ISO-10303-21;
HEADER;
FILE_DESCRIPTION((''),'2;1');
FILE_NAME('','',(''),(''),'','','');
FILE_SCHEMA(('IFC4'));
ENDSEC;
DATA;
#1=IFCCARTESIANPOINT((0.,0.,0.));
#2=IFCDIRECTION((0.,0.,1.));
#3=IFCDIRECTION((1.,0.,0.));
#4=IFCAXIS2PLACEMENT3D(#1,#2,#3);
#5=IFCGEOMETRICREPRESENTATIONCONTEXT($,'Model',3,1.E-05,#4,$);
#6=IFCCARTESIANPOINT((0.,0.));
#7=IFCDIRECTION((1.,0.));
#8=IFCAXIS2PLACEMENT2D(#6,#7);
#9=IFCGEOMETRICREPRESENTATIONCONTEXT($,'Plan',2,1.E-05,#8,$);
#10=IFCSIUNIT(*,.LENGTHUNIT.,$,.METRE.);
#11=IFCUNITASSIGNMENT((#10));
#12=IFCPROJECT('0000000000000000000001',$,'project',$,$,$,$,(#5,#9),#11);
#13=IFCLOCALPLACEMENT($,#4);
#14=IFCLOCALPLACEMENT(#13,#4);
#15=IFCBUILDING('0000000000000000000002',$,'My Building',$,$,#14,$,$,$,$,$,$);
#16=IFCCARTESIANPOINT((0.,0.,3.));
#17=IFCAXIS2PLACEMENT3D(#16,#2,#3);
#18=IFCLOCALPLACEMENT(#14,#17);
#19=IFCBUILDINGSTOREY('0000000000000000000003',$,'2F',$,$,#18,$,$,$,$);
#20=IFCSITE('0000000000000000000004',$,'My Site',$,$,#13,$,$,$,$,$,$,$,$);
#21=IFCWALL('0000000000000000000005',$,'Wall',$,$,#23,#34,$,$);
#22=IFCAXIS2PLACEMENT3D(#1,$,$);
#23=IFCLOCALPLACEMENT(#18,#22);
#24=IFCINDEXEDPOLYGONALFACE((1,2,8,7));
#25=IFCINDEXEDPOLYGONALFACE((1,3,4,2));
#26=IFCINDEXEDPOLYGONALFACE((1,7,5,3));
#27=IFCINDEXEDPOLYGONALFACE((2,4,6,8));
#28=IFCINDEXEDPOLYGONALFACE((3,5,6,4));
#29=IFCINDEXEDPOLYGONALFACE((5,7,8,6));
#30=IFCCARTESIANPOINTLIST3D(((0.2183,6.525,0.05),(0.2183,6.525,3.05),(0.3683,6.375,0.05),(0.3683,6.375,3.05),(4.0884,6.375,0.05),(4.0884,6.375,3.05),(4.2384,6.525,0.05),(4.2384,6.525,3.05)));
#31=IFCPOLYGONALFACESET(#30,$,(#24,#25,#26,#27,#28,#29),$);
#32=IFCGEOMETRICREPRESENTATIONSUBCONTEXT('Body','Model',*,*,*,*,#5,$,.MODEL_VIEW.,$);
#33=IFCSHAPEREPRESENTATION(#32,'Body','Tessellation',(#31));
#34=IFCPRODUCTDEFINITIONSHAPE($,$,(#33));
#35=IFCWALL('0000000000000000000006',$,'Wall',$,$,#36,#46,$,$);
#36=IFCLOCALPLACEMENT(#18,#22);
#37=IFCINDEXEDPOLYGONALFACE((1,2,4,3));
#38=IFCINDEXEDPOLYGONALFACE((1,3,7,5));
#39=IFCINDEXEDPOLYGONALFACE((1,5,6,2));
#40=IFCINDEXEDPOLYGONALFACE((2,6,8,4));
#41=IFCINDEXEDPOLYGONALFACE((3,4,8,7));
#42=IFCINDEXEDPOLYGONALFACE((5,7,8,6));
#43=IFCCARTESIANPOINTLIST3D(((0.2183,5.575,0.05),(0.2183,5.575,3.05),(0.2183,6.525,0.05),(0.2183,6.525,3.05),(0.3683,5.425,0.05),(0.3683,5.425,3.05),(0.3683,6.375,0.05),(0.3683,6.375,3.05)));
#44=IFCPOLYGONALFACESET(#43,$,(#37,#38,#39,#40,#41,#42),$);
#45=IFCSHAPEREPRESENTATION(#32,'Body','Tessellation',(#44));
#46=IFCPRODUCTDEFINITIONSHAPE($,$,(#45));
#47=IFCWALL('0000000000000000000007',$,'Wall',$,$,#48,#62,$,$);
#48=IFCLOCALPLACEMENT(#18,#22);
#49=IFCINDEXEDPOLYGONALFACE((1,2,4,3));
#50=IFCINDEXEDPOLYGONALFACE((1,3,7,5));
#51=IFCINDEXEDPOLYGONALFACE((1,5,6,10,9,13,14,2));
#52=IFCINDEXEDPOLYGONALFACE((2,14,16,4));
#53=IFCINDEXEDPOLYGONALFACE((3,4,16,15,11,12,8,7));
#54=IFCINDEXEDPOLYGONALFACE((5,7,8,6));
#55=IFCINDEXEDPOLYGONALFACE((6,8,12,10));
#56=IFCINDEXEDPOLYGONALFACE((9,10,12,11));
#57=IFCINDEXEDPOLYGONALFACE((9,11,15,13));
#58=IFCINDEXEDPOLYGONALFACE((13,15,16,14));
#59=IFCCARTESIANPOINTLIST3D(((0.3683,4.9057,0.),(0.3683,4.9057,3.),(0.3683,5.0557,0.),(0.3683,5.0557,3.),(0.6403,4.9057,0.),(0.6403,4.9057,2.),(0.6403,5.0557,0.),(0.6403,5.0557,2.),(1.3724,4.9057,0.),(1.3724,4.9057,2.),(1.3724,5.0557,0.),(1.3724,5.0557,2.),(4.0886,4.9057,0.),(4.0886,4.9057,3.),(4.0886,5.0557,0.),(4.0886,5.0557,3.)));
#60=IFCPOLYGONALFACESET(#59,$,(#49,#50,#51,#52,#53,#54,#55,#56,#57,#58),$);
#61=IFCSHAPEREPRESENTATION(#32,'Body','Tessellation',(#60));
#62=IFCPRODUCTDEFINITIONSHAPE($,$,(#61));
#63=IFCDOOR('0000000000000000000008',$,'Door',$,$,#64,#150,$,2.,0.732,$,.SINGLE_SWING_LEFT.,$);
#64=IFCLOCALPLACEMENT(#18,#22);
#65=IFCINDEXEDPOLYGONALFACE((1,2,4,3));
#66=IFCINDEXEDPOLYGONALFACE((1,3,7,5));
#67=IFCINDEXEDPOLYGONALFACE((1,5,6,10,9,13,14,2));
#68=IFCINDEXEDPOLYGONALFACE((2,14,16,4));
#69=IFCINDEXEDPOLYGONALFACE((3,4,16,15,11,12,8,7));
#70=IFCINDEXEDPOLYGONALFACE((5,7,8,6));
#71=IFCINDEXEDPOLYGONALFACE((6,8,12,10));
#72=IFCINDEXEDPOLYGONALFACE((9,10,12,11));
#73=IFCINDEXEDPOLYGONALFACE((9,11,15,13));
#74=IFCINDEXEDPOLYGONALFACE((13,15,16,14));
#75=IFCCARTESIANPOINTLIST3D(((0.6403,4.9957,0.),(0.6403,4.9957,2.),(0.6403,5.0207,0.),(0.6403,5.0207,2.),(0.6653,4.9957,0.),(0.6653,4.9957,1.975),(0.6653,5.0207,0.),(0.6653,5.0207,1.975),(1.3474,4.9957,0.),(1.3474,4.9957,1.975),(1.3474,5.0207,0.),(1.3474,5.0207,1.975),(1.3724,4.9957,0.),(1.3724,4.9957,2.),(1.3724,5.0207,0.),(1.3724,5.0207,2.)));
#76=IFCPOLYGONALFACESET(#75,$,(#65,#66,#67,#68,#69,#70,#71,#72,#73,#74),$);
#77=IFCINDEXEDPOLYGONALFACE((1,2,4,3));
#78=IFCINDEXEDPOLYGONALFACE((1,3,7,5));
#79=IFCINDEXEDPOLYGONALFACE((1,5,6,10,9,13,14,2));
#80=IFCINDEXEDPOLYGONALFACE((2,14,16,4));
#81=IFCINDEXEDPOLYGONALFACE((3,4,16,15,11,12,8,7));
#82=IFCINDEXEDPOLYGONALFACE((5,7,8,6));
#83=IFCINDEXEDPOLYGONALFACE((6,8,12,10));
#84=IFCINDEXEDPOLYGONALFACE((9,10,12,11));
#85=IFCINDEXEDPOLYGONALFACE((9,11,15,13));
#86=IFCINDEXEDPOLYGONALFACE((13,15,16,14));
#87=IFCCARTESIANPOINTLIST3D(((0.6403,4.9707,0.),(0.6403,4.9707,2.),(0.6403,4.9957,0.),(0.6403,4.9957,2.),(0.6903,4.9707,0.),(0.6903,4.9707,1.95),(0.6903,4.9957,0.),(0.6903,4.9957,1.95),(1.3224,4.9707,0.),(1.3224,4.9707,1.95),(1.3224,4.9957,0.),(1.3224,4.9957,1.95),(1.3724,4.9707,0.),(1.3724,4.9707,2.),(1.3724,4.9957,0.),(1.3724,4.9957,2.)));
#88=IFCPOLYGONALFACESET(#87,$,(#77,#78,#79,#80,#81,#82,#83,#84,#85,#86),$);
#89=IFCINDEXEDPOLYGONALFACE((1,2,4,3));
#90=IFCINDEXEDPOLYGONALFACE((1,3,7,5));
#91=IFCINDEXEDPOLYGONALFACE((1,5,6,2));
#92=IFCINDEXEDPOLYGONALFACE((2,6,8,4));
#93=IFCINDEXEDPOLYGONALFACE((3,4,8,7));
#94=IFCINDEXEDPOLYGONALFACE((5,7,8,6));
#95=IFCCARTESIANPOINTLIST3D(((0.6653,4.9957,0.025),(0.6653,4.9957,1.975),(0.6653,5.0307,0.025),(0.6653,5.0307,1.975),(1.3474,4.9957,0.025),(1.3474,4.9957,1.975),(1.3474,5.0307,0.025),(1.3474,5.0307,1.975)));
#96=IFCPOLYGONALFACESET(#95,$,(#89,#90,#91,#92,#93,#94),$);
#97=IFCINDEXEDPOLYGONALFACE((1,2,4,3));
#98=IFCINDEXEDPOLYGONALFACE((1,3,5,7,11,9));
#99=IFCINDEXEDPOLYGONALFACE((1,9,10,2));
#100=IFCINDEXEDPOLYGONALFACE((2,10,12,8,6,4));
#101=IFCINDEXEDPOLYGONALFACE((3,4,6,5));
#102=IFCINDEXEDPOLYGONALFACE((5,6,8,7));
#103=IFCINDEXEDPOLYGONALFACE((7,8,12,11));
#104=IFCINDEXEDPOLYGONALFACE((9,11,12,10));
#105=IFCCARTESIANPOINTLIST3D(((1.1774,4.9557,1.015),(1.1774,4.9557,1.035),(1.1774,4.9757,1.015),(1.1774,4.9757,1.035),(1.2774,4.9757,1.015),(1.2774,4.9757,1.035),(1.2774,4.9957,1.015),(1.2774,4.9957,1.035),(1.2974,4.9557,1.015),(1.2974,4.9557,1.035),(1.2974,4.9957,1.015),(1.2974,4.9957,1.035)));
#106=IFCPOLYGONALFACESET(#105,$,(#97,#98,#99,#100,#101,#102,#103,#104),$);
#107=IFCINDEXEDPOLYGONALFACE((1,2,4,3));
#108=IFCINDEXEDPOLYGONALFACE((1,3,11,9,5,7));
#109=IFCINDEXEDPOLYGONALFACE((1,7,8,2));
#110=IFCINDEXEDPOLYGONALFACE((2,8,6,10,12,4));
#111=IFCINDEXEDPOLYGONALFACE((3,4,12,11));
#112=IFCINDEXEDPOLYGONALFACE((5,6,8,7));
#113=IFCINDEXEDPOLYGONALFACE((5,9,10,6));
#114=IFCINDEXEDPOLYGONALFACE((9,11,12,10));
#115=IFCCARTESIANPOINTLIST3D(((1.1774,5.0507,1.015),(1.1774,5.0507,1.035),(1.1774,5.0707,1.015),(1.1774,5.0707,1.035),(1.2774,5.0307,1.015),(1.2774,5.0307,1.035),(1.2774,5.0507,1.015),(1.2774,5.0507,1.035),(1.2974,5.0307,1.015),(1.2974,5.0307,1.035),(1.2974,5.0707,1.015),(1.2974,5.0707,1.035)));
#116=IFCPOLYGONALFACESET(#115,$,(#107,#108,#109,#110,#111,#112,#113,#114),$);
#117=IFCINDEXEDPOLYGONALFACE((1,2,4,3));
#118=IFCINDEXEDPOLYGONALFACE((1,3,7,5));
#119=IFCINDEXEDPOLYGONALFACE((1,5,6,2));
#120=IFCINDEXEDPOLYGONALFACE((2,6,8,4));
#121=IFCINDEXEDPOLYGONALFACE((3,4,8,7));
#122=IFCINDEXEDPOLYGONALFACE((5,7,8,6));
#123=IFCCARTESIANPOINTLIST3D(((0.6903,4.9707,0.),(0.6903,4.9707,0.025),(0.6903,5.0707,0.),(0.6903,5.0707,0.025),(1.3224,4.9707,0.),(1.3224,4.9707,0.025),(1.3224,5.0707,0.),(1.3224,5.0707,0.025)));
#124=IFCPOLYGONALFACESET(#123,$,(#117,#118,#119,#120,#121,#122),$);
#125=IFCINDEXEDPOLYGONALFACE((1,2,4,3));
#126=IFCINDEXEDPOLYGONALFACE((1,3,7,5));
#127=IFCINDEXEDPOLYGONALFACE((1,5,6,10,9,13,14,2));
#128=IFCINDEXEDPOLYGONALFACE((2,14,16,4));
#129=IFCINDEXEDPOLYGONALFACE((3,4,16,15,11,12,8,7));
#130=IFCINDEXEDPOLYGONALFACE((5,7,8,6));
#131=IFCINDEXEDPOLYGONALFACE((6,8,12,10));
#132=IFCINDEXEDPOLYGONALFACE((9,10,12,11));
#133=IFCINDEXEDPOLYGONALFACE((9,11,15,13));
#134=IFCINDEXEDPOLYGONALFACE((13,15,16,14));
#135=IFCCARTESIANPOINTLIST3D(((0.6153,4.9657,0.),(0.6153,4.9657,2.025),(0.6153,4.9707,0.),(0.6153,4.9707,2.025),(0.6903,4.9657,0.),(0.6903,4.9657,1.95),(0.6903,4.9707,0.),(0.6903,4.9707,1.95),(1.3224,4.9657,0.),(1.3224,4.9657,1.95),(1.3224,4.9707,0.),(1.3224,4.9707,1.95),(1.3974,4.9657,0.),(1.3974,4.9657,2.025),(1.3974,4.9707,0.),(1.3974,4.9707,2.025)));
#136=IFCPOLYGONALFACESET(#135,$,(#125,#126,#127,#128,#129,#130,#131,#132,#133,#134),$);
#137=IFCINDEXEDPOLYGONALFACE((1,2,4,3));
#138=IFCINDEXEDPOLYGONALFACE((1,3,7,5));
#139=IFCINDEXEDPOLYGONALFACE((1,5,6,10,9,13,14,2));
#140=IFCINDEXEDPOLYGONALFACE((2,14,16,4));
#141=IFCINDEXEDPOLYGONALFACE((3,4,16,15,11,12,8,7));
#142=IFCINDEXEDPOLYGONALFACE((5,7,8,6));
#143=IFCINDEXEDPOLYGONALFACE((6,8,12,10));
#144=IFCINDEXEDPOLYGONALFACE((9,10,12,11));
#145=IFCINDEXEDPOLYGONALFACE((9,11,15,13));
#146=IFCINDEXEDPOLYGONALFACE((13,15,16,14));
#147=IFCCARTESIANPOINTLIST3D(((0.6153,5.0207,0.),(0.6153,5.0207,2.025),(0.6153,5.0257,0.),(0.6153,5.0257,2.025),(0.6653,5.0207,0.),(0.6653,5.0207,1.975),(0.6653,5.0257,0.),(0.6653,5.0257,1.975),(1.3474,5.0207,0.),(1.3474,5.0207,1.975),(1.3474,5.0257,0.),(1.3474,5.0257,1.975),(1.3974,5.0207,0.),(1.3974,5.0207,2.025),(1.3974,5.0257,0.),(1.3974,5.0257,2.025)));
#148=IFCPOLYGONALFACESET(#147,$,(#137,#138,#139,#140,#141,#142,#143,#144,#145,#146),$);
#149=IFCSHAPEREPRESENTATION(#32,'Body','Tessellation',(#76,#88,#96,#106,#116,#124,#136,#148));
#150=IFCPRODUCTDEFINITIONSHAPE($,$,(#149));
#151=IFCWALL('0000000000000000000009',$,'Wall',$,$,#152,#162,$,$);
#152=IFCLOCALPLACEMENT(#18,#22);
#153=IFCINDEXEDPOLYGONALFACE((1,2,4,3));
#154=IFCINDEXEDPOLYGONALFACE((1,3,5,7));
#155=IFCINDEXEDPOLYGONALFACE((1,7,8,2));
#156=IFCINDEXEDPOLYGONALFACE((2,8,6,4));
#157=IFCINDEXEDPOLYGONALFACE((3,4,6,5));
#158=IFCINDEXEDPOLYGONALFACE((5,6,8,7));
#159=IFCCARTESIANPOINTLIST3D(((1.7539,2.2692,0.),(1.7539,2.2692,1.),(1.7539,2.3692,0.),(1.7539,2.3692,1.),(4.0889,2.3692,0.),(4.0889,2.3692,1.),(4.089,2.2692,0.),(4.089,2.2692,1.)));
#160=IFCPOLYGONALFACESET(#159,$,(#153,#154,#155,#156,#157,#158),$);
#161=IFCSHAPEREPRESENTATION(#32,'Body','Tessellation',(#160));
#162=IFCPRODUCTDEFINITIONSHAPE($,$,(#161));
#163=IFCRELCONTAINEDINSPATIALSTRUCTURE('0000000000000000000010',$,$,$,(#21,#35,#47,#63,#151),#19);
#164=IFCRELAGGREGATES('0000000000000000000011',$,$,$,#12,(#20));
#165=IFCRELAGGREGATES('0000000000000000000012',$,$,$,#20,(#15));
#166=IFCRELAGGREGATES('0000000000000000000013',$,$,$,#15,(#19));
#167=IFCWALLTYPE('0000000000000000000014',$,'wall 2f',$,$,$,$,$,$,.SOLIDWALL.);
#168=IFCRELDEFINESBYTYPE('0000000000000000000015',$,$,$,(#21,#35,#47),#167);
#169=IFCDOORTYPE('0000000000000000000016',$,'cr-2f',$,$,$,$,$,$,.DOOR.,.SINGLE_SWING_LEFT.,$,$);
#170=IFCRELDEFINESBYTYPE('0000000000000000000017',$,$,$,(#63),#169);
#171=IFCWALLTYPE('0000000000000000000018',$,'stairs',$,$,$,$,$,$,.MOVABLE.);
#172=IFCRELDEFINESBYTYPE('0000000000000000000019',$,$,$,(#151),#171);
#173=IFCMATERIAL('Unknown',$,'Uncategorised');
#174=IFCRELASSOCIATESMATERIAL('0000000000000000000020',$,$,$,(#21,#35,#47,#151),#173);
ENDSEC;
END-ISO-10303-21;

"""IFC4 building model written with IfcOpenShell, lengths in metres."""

from ifc_helpers import new_model, entity, si_unit, frame, origin_with_axes, origin_2d_with_axis, place, context, subcontext, project, spatial, line, indexed_curve, outline, extrude, shape, source, transform, mapped, material, type_object, type_shapes, element, fill, save


model = new_model("IFC4")

# Units and contexts
model_context = context("Model", 3, precision=1e-05, world=origin_with_axes())
plan_context = context("Plan", 2, precision=1e-05, world=origin_2d_with_axis())
body_context_1 = subcontext(model_context, "Body", "Model", "MODEL_VIEW")
body_context_2 = subcontext(plan_context, "Body", "Plan", "PLAN_VIEW")
ifc_project = project(units=[si_unit("LENGTHUNIT", "METRE")], contexts=[model_context, plan_context])

# Site, building, storey
site_placement = place(None, origin_with_axes())
site = spatial("IfcSite", under=ifc_project, at=site_placement, Name="My Site")
building_placement = place(site_placement, origin_with_axes())
building = spatial("IfcBuilding", under=site, at=building_placement, Name="My Building")
storey_placement = place(building_placement, frame((0.0, 0.0, 3.0), z_axis=(0.0, 0.0, 1.0), x_axis=(1.0, 0.0, 0.0)))
storey = spatial("IfcBuildingStorey", under=building, at=storey_placement, Name="2F")

# Shared definitions
ifc_material = material(Name="Unknown", Category="Uncategorised")

# Walls
wall_type_1 = type_object("IfcWallType", Name="wall 2f", PredefinedType="SOLIDWALL")
wall_1_placement = place(storey_placement, frame((4.2384, 6.525, 0.05), z_axis=(0.0, 0.0, 1.0), x_axis=(-1.0, 0.0, 0.0)))
element("IfcWall", 1, at=wall_1_placement, inside=storey, type_object=wall_type_1, material=ifc_material, Name="Wall", context=body_context_1, shape_type="SweptSolid", body=[
    extrude(outline(indexed_curve([(0.0, 0.0), (0.15, 0.15), (3.87, 0.15), (4.02, 0.0)], segments=[line(1, 2, 3, 4, 1)])), origin_with_axes(), (0.0, 0.0, 1.0), 3.0),
])
wall_2_placement = place(storey_placement, frame((0.2183, 6.525, 0.05), z_axis=(0.0, 0.0, 1.0), x_axis=(0.0, -1.0, 0.0)))
element("IfcWall", 2, at=wall_2_placement, inside=storey, type_object=wall_type_1, material=ifc_material, Name="Wall", context=body_context_1, shape_type="SweptSolid", body=[
    extrude(outline(indexed_curve([(0.0, 0.0), (0.15, 0.15), (1.1, 0.15), (0.95, 0.0)], segments=[line(1, 2, 3, 4, 1)])), origin_with_axes(), (0.0, 0.0, 1.0), 3.0),
])

# Wall, opening, door
wall_3_placement = place(storey_placement, frame((0.3683, 4.9057, 0.0), z_axis=(0.0, 0.0, 1.0), x_axis=(1.0, 0.0, 0.0)))
wall_3 = element("IfcWall", 3, at=wall_3_placement, inside=storey, type_object=wall_type_1, material=ifc_material, Name="Wall", context=body_context_1, shape_type="SweptSolid", body=[
    extrude(outline(indexed_curve([(0.0, 0.0), (0.0, 0.15), (3.7202, 0.15), (3.7202, 0.0)], segments=[line(1, 2, 3, 4, 1)])), origin_with_axes(), (0.0, 0.0, 1.0), 3.0),
])
shared_shape_1 = source(origin_with_axes(), body_context_1, "Body", "SweptSolid", [
    extrude(outline(indexed_curve([(0.0, 0.0), (0.732, 0.0), (0.732, 2.0), (0.0, 2.0)], segments=[line(1, 2, 3, 4, 1)])), frame((0.0, -0.6, 0.0), z_axis=(0.0, -1.0, 0.0), x_axis=(1.0, 0.0, 0.0)), (0.0, 0.0, -1.0), 1.2),
])
opening_1_placement = place(wall_3_placement, frame((0.272, 0.065, 0.0), z_axis=(0.0, 0.0, 1.0), x_axis=(1.0, 0.0, 0.0)))
opening_1 = element("IfcOpeningElement", 4, at=opening_1_placement, cuts=wall_3, PredefinedType="OPENING", context=body_context_1, shape_type="MappedRepresentation", body=[
    mapped(shared_shape_1, transform((0.0, 0.0, 0.0), x_axis=(1.0, 0.0, 0.0), y_axis=(0.0, 1.0, 0.0), z_axis=(0.0, 0.0, 1.0), scale=1.0)),
])
door_type_1 = type_object("IfcDoorType", Name="cr-2f", OperationType="SINGLE_SWING_LEFT", PredefinedType="DOOR")
shared_shape_2 = source(origin_with_axes(), body_context_1, "Body", "SweptSolid", [
    extrude(outline(indexed_curve([(0.0, 0.0), (0.0, 2.0), (0.732, 2.0), (0.732, 0.0), (0.707, 0.0), (0.707, 1.975), (0.025, 1.975), (0.025, 0.0)], segments=[line(1, 2, 3, 4, 5, 6, 7, 8, 1)])), frame((0.0, 0.025, 0.0), z_axis=(0.0, -1.0, 0.0), x_axis=(1.0, 0.0, 0.0)), (0.0, 0.0, -1.0), 0.025),
    extrude(outline(indexed_curve([(0.0, 0.0), (0.0, 2.0), (0.732, 2.0), (0.732, 0.0), (0.682, 0.0), (0.682, 1.95), (0.05, 1.95), (0.05, 0.0)], segments=[line(1, 2, 3, 4, 5, 6, 7, 8, 1)])), frame((0.0, 0.0, 0.0), z_axis=(0.0, -1.0, 0.0), x_axis=(1.0, 0.0, 0.0)), (0.0, 0.0, -1.0), 0.025),
    extrude(outline(indexed_curve([(0.0, 0.0), (0.682, 0.0), (0.682, 0.035), (0.0, 0.035)], segments=[line(1, 2, 3, 4, 1)])), frame((0.025, 0.025, 0.025), z_axis=(0.0, 0.0, 1.0), x_axis=(1.0, 0.0, 0.0)), (0.0, 0.0, 1.0), 1.95),
    extrude(outline(indexed_curve([(0.0, 0.0), (0.0, -0.04), (-0.12, -0.04), (-0.12, -0.02), (-0.02, -0.02), (-0.02, 0.0)], segments=[line(1, 2, 3, 4, 5, 6, 1)])), frame((0.657, 0.025, 1.015), z_axis=(0.0, 0.0, 1.0), x_axis=(1.0, 0.0, 0.0)), (0.0, 0.0, 1.0), 0.02),
    extrude(outline(indexed_curve([(0.0, 0.0), (0.0, 0.04), (-0.12, 0.04), (-0.12, 0.02), (-0.02, 0.02), (-0.02, 0.0)], segments=[line(1, 2, 3, 4, 5, 6, 1)])), frame((0.657, 0.06, 1.015), z_axis=(0.0, 0.0, 1.0), x_axis=(1.0, 0.0, 0.0)), (0.0, 0.0, 1.0), 0.02),
    extrude(outline(indexed_curve([(0.0, 0.0), (0.632, 0.0), (0.632, 0.1), (0.0, 0.1)], segments=[line(1, 2, 3, 4, 1)])), frame((0.05, 0.0, 0.0), z_axis=(0.0, 0.0, 1.0), x_axis=(1.0, 0.0, 0.0)), (0.0, 0.0, 1.0), 0.025),
    extrude(outline(indexed_curve([(0.0, 0.0), (0.0, 2.025), (0.782, 2.025), (0.782, 0.0), (0.707, 0.0), (0.707, 1.95), (0.075, 1.95), (0.075, 0.0)], segments=[line(1, 2, 3, 4, 5, 6, 7, 8, 1)])), frame((-0.025, -0.005, 0.0), z_axis=(0.0, -1.0, 0.0), x_axis=(1.0, 0.0, 0.0)), (0.0, 0.0, -1.0), 0.005),
    extrude(outline(indexed_curve([(0.0, 0.0), (0.0, 2.025), (0.782, 2.025), (0.782, 0.0), (0.732, 0.0), (0.732, 1.975), (0.05, 1.975), (0.05, 0.0)], segments=[line(1, 2, 3, 4, 5, 6, 7, 8, 1)])), frame((-0.025, 0.05, 0.0), z_axis=(0.0, -1.0, 0.0), x_axis=(1.0, 0.0, 0.0)), (0.0, 0.0, -1.0), 0.005),
])
shared_shape_3 = source(origin_with_axes(), body_context_2, "Body", "Curve2D", [
    entity("IfcIndexedPolyCurve", entity("IfcCartesianPointList2D", [[0.0, 0.0], [0.0, 0.05], [0.025, 0.05], [0.025, 0.025], [0.05, 0.025], [0.05, 0.0]]), [entity("IfcLineIndex", [1, 2, 3, 4, 5, 6, 1])]),
    entity("IfcIndexedPolyCurve", entity("IfcCartesianPointList2D", [[0.732, 0.0], [0.732, 0.05], [0.707, 0.05], [0.707, 0.025], [0.682, 0.025], [0.682, 0.0]]), [entity("IfcLineIndex", [1, 2, 3, 4, 5, 6, 1])]),
    entity("IfcTrimmedCurve", entity("IfcEllipse", entity("IfcAxis2Placement2D", entity("IfcCartesianPoint", [0.06, 0.05]), entity("IfcDirection", [1.0, 0.0])), 0.647, 0.682), [entity("IfcCartesianPoint", [0.707, 0.05])], [entity("IfcCartesianPoint", [0.06, 0.732])], True, "CARTESIAN"),
    entity("IfcIndexedPolyCurve", entity("IfcCartesianPointList2D", [[0.025, 0.05], [0.06, 0.05], [0.06, 0.732], [0.025, 0.732]]), [entity("IfcLineIndex", [1, 2, 3, 4, 1])]),
])
type_shapes(door_type_1, [shared_shape_2, shared_shape_3])
door_1_placement = place(opening_1_placement, frame((0.0, 0.0, 0.0), z_axis=(0.0, 0.0, 1.0), x_axis=(1.0, 0.0, 0.0)))
door_1 = element("IfcDoor", 5, at=door_1_placement, inside=storey, type_object=door_type_1, Name="Door", OperationType="SINGLE_SWING_LEFT", OverallHeight=2.0, OverallWidth=0.732, shapes=[
    shape(body_context_1, "Body", "MappedRepresentation", [mapped(shared_shape_2, transform((0.0, 0.0, 0.0), x_axis=(1.0, 0.0, 0.0), y_axis=(0.0, 1.0, 0.0), z_axis=(0.0, 0.0, 1.0), scale=1.0))]),
    shape(body_context_2, "Body", "MappedRepresentation", [mapped(shared_shape_3, transform((0.0, 0.0, 0.0), x_axis=(1.0, 0.0, 0.0), y_axis=(0.0, 1.0, 0.0), z_axis=(0.0, 0.0, 1.0), scale=1.0))]),
])
fill(opening_1, door_1)

# Wall
wall_type_2 = type_object("IfcWallType", Name="stairs", PredefinedType="MOVABLE")
wall_4_placement = place(storey_placement, frame((1.7539, 2.2692, 0.0), z_axis=(0.0, 0.0, 1.0), x_axis=(1.0, 0.0, 0.0)))
element("IfcWall", 6, at=wall_4_placement, inside=storey, type_object=wall_type_2, material=ifc_material, Name="Wall", context=body_context_1, shape_type="SweptSolid", body=[
    extrude(outline(indexed_curve([(0.0, 0.0), (0.0, 0.1), (2.3351, 0.1), (2.3351, 0.0)], segments=[line(1, 2, 3, 4, 1)])), origin_with_axes(), (0.0, 0.0, 1.0), 1.0),
])

save(model, "model.ifc")
